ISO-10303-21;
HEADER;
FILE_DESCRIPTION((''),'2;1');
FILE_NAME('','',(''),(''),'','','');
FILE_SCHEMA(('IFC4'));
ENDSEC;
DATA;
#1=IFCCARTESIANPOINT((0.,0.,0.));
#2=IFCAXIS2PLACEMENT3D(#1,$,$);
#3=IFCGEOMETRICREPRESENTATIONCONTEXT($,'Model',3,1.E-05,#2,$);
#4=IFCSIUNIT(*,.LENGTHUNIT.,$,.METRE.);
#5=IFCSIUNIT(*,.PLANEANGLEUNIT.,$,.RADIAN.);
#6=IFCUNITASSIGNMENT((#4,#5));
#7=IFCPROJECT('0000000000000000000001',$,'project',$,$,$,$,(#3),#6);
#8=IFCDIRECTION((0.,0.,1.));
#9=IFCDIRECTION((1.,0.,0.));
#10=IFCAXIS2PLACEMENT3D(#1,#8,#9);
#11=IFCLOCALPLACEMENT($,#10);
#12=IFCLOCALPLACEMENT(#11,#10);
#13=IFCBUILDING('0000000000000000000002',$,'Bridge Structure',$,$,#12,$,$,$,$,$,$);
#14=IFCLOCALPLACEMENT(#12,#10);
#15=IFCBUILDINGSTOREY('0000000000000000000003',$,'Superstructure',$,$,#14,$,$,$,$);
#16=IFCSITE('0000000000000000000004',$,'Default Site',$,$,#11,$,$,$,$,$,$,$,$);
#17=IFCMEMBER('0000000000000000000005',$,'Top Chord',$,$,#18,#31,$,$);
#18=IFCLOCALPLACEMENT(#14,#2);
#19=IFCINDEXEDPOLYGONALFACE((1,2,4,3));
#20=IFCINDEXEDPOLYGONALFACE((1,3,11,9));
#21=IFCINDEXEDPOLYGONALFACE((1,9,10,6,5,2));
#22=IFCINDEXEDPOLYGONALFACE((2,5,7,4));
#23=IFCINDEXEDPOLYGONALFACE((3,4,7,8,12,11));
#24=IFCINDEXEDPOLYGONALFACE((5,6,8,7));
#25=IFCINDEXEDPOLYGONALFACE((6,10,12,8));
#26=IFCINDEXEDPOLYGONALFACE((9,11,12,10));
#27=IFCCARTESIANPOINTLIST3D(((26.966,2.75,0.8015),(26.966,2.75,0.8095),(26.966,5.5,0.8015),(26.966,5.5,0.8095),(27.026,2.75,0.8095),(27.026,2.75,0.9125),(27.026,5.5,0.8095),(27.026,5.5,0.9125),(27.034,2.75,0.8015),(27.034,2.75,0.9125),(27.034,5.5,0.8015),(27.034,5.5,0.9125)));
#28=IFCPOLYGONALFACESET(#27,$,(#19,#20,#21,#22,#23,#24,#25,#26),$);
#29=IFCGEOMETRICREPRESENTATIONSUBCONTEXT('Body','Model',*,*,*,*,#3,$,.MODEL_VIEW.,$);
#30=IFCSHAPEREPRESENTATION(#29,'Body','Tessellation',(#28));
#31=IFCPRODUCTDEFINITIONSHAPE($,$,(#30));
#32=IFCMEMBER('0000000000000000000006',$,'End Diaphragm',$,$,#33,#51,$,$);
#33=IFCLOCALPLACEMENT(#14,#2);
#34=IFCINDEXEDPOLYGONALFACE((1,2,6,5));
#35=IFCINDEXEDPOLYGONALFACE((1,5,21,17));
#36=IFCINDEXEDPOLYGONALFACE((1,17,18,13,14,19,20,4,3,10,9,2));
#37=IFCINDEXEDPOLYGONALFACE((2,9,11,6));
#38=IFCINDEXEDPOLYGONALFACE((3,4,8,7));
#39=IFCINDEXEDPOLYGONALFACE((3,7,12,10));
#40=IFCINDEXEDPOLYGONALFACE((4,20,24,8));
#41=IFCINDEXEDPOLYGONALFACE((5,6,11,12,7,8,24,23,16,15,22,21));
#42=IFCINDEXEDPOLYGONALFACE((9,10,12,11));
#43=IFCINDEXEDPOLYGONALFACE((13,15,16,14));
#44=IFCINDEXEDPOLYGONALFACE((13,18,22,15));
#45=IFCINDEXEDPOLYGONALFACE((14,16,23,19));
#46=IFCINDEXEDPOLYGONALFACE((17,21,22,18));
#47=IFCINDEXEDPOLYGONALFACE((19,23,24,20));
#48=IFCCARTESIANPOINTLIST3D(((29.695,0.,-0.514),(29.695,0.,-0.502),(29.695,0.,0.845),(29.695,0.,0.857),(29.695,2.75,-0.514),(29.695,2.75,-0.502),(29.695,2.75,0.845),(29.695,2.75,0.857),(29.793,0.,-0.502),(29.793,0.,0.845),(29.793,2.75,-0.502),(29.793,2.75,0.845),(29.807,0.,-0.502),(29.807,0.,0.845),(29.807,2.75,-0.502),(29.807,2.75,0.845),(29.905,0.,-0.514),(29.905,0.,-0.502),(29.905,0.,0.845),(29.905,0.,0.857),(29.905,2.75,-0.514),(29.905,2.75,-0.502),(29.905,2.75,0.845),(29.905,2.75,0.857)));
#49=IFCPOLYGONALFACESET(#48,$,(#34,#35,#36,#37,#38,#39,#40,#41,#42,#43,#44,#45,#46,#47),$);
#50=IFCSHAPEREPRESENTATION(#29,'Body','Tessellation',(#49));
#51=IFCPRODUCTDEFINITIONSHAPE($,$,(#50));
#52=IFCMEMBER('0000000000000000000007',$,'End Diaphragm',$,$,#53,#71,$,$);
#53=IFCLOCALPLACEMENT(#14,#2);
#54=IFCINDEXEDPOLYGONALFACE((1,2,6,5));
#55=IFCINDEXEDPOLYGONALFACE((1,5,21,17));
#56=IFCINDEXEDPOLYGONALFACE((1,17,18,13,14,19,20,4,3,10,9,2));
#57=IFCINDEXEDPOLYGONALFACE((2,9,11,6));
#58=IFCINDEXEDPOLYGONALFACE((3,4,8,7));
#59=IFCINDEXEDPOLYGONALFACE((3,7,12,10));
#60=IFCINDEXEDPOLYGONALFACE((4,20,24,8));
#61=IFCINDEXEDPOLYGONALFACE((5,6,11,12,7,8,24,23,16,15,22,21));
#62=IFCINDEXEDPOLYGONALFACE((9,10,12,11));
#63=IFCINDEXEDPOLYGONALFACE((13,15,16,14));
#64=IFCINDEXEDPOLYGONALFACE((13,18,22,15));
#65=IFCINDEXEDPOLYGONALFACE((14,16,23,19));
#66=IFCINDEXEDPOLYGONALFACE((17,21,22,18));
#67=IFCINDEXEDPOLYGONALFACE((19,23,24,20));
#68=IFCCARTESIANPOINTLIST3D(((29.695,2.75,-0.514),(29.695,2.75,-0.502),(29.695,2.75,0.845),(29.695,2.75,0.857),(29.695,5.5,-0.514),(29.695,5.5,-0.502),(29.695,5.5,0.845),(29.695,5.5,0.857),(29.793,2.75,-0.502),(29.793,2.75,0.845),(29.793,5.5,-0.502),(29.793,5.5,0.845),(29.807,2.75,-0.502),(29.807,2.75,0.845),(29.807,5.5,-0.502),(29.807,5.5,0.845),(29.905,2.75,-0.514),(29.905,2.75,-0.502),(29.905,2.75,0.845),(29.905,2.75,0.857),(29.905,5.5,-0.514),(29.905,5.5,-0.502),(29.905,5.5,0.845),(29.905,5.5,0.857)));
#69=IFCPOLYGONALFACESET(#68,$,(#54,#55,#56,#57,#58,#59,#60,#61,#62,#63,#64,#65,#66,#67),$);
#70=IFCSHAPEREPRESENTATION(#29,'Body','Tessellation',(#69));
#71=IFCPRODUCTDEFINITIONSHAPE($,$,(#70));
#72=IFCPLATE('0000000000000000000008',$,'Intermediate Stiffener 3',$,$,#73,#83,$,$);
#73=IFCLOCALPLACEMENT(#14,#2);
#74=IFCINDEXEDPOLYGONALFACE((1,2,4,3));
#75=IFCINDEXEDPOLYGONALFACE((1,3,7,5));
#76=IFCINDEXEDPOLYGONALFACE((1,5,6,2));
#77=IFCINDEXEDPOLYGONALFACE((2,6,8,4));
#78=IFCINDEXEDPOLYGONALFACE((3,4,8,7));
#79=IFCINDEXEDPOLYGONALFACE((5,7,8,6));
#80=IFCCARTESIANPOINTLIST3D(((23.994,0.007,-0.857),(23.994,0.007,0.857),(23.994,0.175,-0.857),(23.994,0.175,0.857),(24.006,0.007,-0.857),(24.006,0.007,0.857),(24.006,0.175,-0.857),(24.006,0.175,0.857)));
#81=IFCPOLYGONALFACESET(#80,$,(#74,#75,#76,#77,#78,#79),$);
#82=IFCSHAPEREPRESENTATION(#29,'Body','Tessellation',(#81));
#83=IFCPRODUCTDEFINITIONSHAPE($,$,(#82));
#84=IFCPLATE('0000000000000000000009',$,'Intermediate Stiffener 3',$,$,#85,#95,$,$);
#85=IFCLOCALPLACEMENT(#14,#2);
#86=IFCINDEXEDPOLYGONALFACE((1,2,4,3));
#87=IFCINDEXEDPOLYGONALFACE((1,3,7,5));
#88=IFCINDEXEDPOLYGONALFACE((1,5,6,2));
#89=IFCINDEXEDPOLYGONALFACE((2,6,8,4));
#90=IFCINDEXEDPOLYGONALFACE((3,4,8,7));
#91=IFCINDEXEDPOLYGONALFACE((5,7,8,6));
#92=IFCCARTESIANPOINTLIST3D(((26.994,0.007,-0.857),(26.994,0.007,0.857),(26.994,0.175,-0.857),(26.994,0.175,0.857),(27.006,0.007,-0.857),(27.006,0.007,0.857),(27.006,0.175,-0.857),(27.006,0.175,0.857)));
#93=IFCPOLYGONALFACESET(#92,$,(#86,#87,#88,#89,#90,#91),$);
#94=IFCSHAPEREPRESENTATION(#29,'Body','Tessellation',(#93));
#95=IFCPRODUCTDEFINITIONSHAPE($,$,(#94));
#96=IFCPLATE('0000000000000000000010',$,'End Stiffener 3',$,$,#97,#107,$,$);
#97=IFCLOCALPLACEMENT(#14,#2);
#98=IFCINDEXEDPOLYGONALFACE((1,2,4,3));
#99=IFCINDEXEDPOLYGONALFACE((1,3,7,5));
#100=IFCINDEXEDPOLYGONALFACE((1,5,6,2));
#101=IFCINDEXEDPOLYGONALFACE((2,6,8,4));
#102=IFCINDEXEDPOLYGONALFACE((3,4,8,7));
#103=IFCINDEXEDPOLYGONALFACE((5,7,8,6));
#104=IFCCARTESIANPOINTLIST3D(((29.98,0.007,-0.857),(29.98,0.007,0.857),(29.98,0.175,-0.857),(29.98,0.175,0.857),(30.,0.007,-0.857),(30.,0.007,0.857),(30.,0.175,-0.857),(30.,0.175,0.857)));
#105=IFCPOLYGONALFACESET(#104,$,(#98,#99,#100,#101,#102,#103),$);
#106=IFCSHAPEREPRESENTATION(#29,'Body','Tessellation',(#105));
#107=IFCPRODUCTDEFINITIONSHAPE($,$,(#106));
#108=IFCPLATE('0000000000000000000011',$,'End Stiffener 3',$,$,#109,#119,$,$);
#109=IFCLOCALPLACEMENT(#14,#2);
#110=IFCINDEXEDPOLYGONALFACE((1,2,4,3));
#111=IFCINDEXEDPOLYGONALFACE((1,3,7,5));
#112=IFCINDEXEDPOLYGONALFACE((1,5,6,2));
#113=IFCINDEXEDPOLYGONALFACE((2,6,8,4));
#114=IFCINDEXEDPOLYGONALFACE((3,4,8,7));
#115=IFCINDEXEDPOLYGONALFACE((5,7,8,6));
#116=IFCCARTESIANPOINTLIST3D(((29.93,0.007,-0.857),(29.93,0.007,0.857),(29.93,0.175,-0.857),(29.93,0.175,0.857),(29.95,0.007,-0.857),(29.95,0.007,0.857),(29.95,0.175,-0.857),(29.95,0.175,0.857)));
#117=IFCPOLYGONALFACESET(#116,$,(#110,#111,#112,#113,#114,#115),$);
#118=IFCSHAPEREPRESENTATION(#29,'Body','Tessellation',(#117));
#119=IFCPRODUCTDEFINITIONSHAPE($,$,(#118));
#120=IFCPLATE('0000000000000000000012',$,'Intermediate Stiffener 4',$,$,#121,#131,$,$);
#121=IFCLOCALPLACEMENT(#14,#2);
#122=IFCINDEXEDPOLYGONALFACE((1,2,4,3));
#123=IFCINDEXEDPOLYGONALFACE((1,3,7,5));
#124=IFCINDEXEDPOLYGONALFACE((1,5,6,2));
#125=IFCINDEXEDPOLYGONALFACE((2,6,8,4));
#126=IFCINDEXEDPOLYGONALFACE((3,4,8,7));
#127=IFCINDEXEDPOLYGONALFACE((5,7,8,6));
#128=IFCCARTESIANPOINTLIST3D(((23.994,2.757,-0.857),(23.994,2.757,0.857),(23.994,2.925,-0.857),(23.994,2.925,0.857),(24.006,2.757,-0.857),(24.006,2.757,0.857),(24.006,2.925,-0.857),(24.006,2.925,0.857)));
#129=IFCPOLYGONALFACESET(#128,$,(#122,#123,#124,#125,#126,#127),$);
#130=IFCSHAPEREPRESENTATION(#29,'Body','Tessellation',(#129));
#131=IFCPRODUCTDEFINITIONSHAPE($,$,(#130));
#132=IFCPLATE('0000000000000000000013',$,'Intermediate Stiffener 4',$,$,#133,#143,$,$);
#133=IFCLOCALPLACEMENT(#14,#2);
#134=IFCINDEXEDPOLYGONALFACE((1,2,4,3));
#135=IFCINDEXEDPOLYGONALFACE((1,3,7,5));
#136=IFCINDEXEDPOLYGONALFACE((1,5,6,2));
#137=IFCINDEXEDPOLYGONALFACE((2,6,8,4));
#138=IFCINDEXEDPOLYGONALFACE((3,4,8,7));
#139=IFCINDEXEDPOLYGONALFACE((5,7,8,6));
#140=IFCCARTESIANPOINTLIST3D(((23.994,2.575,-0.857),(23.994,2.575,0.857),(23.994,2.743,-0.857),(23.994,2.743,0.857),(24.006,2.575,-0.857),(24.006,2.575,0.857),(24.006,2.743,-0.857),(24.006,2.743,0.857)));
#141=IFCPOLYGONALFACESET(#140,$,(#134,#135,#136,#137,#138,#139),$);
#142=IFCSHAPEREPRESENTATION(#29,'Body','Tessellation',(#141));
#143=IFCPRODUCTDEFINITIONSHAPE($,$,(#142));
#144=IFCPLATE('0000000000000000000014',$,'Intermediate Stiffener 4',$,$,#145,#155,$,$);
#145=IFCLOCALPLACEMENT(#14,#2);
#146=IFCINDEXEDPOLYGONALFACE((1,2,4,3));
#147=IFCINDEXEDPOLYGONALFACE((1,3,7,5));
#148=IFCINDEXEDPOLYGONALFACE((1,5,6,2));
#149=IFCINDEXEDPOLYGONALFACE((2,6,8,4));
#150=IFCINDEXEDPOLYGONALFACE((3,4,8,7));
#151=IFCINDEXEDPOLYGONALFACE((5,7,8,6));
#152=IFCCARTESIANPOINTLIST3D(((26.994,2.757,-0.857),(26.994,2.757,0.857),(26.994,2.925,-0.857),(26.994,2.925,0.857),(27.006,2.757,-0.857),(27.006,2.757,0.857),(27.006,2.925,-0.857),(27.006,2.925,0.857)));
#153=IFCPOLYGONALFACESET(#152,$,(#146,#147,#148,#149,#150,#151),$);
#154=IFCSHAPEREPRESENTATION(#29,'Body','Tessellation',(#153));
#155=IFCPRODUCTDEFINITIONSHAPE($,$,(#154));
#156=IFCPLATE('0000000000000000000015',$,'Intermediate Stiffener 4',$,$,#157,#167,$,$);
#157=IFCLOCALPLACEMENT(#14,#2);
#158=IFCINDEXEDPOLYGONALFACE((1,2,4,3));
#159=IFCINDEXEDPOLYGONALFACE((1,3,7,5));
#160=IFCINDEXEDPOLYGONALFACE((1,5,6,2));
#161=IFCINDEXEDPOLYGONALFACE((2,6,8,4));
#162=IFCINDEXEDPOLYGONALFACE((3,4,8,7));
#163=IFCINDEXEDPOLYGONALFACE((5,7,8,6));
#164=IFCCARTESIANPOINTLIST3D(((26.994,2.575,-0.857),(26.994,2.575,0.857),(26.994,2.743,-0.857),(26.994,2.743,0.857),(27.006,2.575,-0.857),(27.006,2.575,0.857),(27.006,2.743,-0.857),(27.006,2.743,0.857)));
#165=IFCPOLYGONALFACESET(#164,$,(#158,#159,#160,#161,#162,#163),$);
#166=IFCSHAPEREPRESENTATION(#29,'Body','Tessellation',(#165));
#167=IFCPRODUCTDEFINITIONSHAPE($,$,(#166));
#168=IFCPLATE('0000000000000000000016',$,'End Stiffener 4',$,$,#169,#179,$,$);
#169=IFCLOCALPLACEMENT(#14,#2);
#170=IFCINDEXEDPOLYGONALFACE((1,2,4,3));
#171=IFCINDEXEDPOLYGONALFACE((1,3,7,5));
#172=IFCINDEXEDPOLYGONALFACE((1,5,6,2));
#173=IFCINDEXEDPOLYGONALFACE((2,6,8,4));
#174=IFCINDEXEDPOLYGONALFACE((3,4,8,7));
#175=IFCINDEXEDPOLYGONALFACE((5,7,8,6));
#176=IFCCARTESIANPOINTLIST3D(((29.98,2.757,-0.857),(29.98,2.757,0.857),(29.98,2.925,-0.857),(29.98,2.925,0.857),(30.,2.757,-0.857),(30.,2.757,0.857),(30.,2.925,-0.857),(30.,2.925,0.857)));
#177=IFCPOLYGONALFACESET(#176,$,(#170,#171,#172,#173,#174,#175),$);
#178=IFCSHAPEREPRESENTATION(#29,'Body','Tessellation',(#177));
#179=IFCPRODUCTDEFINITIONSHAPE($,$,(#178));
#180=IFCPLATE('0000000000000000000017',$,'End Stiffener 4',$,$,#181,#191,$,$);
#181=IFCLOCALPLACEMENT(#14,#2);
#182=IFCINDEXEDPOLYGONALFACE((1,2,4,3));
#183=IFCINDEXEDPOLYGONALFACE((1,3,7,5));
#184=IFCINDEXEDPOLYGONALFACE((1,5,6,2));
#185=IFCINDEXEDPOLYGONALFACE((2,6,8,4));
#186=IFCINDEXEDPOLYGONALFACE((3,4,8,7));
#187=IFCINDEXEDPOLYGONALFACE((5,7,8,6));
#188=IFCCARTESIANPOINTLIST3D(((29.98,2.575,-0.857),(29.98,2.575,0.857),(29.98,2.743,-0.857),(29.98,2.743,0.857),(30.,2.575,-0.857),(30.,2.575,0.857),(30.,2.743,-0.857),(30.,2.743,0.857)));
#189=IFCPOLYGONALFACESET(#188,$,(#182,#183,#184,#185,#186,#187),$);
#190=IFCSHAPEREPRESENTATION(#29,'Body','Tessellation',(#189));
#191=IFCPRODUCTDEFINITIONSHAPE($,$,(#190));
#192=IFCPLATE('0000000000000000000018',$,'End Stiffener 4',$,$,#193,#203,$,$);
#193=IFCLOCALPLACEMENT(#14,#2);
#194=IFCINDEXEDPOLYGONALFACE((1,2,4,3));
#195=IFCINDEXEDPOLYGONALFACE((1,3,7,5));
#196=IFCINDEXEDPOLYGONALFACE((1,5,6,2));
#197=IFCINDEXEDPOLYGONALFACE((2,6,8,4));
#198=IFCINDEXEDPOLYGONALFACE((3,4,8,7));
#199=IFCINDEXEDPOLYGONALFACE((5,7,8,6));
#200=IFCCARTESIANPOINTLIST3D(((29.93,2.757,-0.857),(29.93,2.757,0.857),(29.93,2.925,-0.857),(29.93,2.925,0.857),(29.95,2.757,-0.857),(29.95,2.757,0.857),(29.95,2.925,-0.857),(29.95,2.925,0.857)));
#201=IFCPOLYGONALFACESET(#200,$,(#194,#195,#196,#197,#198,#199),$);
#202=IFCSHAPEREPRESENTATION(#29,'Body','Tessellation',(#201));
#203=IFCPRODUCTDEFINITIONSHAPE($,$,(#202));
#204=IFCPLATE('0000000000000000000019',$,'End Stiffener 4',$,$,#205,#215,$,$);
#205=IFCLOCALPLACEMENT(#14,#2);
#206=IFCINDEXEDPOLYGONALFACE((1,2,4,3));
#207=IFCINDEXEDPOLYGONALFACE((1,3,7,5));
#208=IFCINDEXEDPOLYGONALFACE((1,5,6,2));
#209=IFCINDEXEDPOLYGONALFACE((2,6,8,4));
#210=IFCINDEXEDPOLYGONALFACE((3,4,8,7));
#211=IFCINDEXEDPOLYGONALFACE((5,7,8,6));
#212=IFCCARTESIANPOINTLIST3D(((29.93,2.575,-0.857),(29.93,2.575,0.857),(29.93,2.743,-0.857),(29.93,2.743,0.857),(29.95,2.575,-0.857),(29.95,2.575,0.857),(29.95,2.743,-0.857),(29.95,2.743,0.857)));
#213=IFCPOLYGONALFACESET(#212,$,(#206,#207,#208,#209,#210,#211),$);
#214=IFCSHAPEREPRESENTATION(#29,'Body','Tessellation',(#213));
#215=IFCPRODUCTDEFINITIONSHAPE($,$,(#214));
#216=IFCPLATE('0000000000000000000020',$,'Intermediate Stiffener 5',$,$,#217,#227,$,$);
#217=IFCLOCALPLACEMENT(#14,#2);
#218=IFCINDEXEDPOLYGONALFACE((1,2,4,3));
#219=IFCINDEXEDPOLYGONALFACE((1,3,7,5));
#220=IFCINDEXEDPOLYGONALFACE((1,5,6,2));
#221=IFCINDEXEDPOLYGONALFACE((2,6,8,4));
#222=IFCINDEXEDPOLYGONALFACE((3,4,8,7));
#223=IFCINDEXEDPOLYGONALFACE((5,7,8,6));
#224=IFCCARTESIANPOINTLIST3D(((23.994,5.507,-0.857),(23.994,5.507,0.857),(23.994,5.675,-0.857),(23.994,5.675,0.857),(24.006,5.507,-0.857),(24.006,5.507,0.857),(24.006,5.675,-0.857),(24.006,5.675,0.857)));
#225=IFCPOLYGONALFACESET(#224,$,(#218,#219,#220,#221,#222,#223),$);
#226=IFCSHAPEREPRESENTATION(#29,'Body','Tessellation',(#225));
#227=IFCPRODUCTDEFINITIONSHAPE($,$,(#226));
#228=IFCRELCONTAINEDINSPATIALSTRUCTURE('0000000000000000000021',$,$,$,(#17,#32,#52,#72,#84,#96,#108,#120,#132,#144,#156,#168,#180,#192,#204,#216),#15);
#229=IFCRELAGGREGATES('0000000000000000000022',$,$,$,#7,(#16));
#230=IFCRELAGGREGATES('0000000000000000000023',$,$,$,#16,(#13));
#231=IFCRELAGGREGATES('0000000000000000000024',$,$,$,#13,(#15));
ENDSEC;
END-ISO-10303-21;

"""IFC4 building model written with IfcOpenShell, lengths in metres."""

from ifc_helpers import new_model, si_unit, frame, origin, origin_with_axes, origin_2d_with_axis, place, context, subcontext, project, spatial, rectangle, i_section, l_section, extrude, element, save


model = new_model("IFC4")

# Units and contexts
model_context = context("Model", 3, precision=1e-05, world=origin())
body_context = subcontext(model_context, "Body", "Model", "MODEL_VIEW")
ifc_project = project(units=[si_unit("LENGTHUNIT", "METRE"), si_unit("PLANEANGLEUNIT", "RADIAN")], contexts=[model_context])

# Site, building, storey
site_placement = place(None, origin_with_axes())
site = spatial("IfcSite", under=ifc_project, at=site_placement, Name="Default Site")
building_placement = place(site_placement, origin_with_axes())
building = spatial("IfcBuilding", under=site, at=building_placement, Name="Bridge Structure")
storey_placement = place(building_placement, origin_with_axes())
storey = spatial("IfcBuildingStorey", under=building, at=storey_placement, Name="Superstructure")

# Members
for number, where, z_axis, x_axis, name in (
    (1, (27.0, 2.75, 0.857), (0.0, 1.0, 0.0), (-1.0, 0.0, 0.0), "Top Chord"),
):
    element("IfcMember", number, at=place(storey_placement, frame(where, z_axis=z_axis, x_axis=x_axis)), inside=storey, Name=name, context=body_context, shape_type="SweptSolid", body=[
        extrude(l_section(Depth=0.111, Width=0.068, Thickness=0.008, at=origin_2d_with_axis()), origin_with_axes(), (0.0, 0.0, 1.0), 2.75),
    ])
for number, where, z_axis, x_axis, name in (
    (2, (29.8, 0.0, 0.1715), (0.0, 1.0, 0.0), (-1.0, 0.0, 0.0), "End Diaphragm"),
    (3, (29.8, 2.75, 0.1715), (0.0, 1.0, 0.0), (-1.0, 0.0, 0.0), "End Diaphragm"),
):
    element("IfcMember", number, at=place(storey_placement, frame(where, z_axis=z_axis, x_axis=x_axis)), inside=storey, Name=name, context=body_context, shape_type="SweptSolid", body=[
        extrude(i_section(OverallWidth=0.21, OverallDepth=1.371, WebThickness=0.014, FlangeThickness=0.012, at=origin_2d_with_axis()), origin_with_axes(), (0.0, 0.0, 1.0), 2.75),
    ])

# Plates
for number, where, z_axis, x_axis, name in (
    (4, (24.0, 0.091, -0.857), (0.0, 0.0, 1.0), (1.0, 0.0, 0.0), "Intermediate Stiffener 3"),
    (5, (27.0, 0.091, -0.857), (0.0, 0.0, 1.0), (1.0, 0.0, 0.0), "Intermediate Stiffener 3"),
):
    element("IfcPlate", number, at=place(storey_placement, frame(where, z_axis=z_axis, x_axis=x_axis)), inside=storey, Name=name, context=body_context, shape_type="SweptSolid", body=[
        extrude(rectangle(XDim=0.012, YDim=0.168, at=origin_2d_with_axis()), origin_with_axes(), (0.0, 0.0, 1.0), 1.714),
    ])
for number, where, z_axis, x_axis, name in (
    (6, (29.99, 0.091, -0.857), (0.0, 0.0, 1.0), (1.0, 0.0, 0.0), "End Stiffener 3"),
    (7, (29.94, 0.091, -0.857), (0.0, 0.0, 1.0), (1.0, 0.0, 0.0), "End Stiffener 3"),
):
    element("IfcPlate", number, at=place(storey_placement, frame(where, z_axis=z_axis, x_axis=x_axis)), inside=storey, Name=name, context=body_context, shape_type="SweptSolid", body=[
        extrude(rectangle(XDim=0.02, YDim=0.168, at=origin_2d_with_axis()), origin_with_axes(), (0.0, 0.0, 1.0), 1.714),
    ])
for number, where, z_axis, x_axis, name in (
    (8, (24.0, 2.841, -0.857), (0.0, 0.0, 1.0), (1.0, 0.0, 0.0), "Intermediate Stiffener 4"),
    (9, (24.0, 2.659, -0.857), (0.0, 0.0, 1.0), (1.0, 0.0, 0.0), "Intermediate Stiffener 4"),
    (10, (27.0, 2.841, -0.857), (0.0, 0.0, 1.0), (1.0, 0.0, 0.0), "Intermediate Stiffener 4"),
    (11, (27.0, 2.659, -0.857), (0.0, 0.0, 1.0), (1.0, 0.0, 0.0), "Intermediate Stiffener 4"),
):
    element("IfcPlate", number, at=place(storey_placement, frame(where, z_axis=z_axis, x_axis=x_axis)), inside=storey, Name=name, context=body_context, shape_type="SweptSolid", body=[
        extrude(rectangle(XDim=0.012, YDim=0.168, at=origin_2d_with_axis()), origin_with_axes(), (0.0, 0.0, 1.0), 1.714),
    ])
for number, where, z_axis, x_axis, name in (
    (12, (29.99, 2.841, -0.857), (0.0, 0.0, 1.0), (1.0, 0.0, 0.0), "End Stiffener 4"),
    (13, (29.99, 2.659, -0.857), (0.0, 0.0, 1.0), (1.0, 0.0, 0.0), "End Stiffener 4"),
    (14, (29.94, 2.841, -0.857), (0.0, 0.0, 1.0), (1.0, 0.0, 0.0), "End Stiffener 4"),
    (15, (29.94, 2.659, -0.857), (0.0, 0.0, 1.0), (1.0, 0.0, 0.0), "End Stiffener 4"),
):
    element("IfcPlate", number, at=place(storey_placement, frame(where, z_axis=z_axis, x_axis=x_axis)), inside=storey, Name=name, context=body_context, shape_type="SweptSolid", body=[
        extrude(rectangle(XDim=0.02, YDim=0.168, at=origin_2d_with_axis()), origin_with_axes(), (0.0, 0.0, 1.0), 1.714),
    ])
for number, where, z_axis, x_axis, name in (
    (16, (24.0, 5.591, -0.857), (0.0, 0.0, 1.0), (1.0, 0.0, 0.0), "Intermediate Stiffener 5"),
):
    element("IfcPlate", number, at=place(storey_placement, frame(where, z_axis=z_axis, x_axis=x_axis)), inside=storey, Name=name, context=body_context, shape_type="SweptSolid", body=[
        extrude(rectangle(XDim=0.012, YDim=0.168, at=origin_2d_with_axis()), origin_with_axes(), (0.0, 0.0, 1.0), 1.714),
    ])

save(model, "model.ifc")
